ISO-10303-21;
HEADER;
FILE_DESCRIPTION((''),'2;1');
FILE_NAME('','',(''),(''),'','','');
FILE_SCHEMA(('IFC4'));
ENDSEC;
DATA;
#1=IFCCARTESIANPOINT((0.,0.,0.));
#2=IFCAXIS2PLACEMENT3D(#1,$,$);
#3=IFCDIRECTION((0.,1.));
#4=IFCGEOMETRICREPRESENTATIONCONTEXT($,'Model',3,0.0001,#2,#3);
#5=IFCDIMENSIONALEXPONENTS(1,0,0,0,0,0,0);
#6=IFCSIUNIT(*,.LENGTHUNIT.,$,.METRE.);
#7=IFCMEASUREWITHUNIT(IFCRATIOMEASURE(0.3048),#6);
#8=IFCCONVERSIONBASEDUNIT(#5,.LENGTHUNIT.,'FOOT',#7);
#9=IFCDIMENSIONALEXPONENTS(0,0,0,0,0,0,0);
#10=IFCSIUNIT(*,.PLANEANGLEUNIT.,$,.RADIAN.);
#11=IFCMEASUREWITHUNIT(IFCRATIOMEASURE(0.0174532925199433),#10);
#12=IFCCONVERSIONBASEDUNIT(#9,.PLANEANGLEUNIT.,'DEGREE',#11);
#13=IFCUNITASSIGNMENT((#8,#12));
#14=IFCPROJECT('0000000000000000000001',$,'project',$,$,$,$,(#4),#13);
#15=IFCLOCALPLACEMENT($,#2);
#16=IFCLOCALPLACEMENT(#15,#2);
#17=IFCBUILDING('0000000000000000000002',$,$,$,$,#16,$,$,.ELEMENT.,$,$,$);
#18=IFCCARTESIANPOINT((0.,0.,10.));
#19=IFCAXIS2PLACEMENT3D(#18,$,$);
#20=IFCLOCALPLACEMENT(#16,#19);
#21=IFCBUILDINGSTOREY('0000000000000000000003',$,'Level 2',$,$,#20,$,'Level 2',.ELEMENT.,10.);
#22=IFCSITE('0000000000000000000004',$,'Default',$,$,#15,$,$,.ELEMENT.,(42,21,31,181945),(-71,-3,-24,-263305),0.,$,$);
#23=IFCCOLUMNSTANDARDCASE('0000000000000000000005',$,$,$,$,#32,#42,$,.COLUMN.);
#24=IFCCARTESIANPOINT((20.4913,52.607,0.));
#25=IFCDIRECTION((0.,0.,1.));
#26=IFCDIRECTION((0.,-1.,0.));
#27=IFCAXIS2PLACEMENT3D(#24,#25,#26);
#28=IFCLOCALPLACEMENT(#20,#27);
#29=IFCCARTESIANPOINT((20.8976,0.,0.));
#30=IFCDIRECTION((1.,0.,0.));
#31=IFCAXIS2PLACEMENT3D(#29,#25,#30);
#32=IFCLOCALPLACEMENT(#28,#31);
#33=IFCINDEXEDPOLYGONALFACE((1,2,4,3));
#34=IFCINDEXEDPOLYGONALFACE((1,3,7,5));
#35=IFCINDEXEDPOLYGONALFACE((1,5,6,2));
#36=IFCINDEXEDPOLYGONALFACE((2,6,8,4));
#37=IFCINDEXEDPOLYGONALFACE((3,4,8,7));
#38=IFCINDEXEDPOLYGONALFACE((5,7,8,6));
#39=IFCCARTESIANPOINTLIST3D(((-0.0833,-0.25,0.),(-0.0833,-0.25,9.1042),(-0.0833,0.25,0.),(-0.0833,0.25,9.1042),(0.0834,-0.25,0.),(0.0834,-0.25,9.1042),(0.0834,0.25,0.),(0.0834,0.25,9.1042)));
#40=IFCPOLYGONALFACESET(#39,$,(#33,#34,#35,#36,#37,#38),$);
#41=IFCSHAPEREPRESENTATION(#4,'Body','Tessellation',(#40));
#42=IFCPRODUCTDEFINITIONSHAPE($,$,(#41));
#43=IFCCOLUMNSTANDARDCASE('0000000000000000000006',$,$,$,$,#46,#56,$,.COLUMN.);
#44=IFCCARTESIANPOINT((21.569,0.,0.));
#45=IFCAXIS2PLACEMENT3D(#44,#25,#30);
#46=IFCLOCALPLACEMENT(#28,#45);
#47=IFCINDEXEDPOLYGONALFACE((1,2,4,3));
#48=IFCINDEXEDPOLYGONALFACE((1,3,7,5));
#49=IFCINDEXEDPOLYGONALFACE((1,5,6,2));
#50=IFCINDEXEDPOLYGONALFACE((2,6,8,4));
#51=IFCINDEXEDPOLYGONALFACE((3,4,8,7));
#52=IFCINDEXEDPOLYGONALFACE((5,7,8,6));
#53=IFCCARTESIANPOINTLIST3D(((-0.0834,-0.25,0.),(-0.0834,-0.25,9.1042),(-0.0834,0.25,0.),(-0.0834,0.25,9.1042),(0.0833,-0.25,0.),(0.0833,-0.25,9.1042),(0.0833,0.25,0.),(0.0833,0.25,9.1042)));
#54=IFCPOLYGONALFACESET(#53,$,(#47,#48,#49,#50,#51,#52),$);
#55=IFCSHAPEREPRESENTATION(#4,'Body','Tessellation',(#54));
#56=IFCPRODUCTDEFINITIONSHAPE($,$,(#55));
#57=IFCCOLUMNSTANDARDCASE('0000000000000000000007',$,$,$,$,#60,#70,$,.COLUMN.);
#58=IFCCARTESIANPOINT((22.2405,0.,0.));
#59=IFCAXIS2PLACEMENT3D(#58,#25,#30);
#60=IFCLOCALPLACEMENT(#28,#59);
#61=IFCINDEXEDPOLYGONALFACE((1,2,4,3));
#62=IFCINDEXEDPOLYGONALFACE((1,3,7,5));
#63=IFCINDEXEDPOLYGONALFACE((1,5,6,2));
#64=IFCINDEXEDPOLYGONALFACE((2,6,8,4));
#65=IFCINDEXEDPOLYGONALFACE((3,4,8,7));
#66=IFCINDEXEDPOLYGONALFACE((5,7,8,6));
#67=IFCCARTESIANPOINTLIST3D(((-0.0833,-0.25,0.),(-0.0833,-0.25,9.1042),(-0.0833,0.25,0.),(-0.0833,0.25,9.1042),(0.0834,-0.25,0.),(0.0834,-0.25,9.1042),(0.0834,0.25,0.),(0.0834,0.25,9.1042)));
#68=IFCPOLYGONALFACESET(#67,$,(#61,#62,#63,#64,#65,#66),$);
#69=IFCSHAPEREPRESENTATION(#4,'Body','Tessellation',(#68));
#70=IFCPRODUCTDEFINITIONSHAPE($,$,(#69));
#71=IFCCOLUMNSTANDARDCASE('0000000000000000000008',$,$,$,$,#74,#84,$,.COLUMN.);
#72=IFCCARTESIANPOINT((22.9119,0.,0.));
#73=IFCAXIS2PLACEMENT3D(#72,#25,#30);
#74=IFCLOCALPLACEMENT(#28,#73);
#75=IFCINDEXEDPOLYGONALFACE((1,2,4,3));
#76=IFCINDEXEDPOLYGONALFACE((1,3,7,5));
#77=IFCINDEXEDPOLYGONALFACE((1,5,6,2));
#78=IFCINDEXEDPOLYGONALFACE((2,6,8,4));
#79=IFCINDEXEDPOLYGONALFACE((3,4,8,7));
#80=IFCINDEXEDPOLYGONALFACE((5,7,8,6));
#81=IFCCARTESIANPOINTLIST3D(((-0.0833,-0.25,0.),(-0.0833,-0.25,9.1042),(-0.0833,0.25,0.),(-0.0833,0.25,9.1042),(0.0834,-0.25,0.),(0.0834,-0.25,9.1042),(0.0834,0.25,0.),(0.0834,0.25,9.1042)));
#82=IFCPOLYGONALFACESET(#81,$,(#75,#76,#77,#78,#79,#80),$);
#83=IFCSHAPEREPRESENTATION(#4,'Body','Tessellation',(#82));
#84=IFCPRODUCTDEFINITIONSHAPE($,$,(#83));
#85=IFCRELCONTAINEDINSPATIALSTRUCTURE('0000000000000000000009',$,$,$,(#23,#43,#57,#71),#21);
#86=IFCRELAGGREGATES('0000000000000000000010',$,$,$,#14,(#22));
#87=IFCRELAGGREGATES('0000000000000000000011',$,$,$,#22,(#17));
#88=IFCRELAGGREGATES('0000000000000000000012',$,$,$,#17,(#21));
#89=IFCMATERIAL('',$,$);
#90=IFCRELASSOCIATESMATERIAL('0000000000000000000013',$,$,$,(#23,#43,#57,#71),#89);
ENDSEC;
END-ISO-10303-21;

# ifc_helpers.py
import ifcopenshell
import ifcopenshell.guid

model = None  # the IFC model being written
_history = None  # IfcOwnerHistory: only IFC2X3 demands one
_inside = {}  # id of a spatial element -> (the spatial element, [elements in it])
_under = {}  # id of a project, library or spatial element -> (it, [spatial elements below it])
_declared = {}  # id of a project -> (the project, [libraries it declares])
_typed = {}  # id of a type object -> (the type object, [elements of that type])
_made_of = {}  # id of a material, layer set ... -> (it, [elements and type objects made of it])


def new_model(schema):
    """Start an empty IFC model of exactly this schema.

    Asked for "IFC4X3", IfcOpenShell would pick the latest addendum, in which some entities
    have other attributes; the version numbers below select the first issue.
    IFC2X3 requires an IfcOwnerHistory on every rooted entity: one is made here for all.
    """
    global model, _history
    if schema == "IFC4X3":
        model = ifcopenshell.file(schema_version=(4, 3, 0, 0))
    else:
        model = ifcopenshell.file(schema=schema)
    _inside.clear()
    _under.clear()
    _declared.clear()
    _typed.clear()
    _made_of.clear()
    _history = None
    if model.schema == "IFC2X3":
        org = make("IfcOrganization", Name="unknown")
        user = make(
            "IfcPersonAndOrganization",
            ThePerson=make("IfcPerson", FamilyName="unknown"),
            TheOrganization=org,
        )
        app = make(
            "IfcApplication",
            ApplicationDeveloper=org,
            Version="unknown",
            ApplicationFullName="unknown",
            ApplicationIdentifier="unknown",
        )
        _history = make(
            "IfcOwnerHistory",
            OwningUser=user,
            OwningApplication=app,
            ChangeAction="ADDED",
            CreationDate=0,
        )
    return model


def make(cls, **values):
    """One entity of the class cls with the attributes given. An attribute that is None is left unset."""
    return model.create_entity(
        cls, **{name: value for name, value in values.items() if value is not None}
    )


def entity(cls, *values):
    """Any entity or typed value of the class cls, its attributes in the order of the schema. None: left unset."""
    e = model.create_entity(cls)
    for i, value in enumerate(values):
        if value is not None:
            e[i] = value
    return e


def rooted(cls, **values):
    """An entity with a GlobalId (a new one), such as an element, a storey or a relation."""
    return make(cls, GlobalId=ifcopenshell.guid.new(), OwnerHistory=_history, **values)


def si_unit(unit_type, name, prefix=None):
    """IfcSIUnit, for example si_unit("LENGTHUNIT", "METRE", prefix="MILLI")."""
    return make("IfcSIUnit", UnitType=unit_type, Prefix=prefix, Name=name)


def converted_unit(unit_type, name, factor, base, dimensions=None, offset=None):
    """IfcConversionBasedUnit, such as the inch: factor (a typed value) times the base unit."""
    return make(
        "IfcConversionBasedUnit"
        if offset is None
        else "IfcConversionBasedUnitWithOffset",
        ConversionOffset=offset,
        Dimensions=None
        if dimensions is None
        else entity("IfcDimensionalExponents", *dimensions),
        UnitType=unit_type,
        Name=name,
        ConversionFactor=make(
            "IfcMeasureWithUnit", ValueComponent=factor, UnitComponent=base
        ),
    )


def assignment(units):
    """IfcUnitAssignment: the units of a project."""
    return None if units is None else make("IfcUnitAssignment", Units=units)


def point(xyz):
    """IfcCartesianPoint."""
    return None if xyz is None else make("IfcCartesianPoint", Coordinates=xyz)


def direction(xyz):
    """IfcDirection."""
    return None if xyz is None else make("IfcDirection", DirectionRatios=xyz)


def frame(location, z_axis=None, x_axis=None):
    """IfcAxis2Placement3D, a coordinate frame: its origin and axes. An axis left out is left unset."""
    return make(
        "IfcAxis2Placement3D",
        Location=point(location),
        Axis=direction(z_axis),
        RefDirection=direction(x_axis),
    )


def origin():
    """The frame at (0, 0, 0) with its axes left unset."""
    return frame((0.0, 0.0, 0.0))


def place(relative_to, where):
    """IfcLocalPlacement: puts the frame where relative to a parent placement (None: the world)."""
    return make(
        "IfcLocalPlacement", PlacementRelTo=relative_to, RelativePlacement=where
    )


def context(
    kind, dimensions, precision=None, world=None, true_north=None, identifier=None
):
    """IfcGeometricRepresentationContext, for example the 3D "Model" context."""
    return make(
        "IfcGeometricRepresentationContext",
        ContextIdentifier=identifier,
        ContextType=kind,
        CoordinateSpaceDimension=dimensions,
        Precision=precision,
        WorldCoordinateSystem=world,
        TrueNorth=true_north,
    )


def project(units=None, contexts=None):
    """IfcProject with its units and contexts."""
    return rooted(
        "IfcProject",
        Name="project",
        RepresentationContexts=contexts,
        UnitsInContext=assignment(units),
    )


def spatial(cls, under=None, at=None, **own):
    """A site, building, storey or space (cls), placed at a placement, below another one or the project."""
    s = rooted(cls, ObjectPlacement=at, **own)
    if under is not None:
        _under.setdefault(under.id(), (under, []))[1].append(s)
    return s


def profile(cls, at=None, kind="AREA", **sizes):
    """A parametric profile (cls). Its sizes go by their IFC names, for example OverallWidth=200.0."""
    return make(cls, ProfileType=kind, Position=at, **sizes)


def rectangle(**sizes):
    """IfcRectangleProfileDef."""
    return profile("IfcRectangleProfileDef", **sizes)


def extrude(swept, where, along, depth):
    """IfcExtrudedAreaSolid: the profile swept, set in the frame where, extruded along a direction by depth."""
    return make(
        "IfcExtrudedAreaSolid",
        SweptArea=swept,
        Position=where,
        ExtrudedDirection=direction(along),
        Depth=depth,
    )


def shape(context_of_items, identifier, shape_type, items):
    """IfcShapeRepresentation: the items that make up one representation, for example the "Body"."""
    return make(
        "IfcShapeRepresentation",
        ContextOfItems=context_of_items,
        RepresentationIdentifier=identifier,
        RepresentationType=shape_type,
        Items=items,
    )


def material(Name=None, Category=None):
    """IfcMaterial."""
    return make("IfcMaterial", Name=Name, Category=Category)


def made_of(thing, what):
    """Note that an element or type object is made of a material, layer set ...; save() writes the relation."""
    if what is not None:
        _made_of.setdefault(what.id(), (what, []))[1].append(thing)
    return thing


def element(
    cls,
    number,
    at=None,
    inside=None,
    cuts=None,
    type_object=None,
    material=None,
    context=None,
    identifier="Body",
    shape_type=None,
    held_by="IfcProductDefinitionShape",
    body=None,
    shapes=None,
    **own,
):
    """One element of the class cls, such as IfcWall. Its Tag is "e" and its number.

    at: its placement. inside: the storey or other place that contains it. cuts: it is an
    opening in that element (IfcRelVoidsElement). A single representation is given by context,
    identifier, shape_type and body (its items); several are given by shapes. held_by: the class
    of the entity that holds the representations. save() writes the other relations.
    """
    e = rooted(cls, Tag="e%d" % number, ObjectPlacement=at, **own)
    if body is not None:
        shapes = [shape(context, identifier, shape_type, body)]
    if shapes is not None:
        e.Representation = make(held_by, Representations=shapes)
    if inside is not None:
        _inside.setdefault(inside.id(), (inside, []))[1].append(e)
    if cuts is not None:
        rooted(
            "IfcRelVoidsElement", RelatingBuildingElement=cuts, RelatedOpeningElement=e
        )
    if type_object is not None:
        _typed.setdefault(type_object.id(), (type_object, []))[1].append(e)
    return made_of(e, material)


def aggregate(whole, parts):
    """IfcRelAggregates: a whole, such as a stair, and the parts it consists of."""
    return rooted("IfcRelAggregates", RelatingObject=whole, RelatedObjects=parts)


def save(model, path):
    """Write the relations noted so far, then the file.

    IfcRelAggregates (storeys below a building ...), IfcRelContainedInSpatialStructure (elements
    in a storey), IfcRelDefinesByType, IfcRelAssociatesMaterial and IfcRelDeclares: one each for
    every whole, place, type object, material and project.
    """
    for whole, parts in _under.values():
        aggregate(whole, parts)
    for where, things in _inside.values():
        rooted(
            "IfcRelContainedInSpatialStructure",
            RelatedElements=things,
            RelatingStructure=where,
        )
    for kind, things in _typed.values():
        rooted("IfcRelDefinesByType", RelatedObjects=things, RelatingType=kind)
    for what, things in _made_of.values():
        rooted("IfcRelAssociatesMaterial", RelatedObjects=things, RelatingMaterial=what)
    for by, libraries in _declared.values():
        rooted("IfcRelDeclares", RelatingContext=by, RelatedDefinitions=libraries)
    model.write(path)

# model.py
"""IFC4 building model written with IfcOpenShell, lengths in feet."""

from ifc_helpers import new_model, entity, si_unit, converted_unit, direction, frame, origin, place, context, project, spatial, rectangle, extrude, material, element, save


model = new_model("IFC4")

# Units and contexts
model_context = context("Model", 3, precision=0.0001, world=origin(), true_north=direction((0.0, 1.0)))
ifc_project = project(units=[converted_unit("LENGTHUNIT", "FOOT", entity("IfcRatioMeasure", 0.3048), si_unit("LENGTHUNIT", "METRE"), dimensions=[1, 0, 0, 0, 0, 0, 0]), converted_unit("PLANEANGLEUNIT", "DEGREE", entity("IfcRatioMeasure", 0.0174532925199433), si_unit("PLANEANGLEUNIT", "RADIAN"), dimensions=[0, 0, 0, 0, 0, 0, 0])], contexts=[model_context])

# Site, building, storey
site_placement = place(None, origin())
site = spatial("IfcSite", under=ifc_project, at=site_placement, Name="Default", CompositionType="ELEMENT", RefLatitude=(42, 21, 31, 181945), RefLongitude=(-71, -3, -24, -263305), RefElevation=0.0)
building_placement = place(site_placement, origin())
building = spatial("IfcBuilding", under=site, at=building_placement, CompositionType="ELEMENT")
storey_placement = place(building_placement, frame((0.0, 0.0, 10.0)))
storey = spatial("IfcBuildingStorey", under=building, at=storey_placement, Name="Level 2", LongName="Level 2", CompositionType="ELEMENT", Elevation=10.0)

# Columns
ifc_material_1 = material(Name="")
placement_1 = place(storey_placement, frame((20.4913, 52.607, 0.0), z_axis=(0.0, 0.0, 1.0), x_axis=(0.0, -1.0, 0.0)))
for number, where, z_axis, x_axis in (
    (1, (20.8976, 0.0, 0.0), (0.0, 0.0, 1.0), (1.0, 0.0, 0.0)),
    (2, (21.569, 0.0, 0.0), (0.0, 0.0, 1.0), (1.0, 0.0, 0.0)),
    (3, (22.2405, 0.0, 0.0), (0.0, 0.0, 1.0), (1.0, 0.0, 0.0)),
    (4, (22.9119, 0.0, 0.0), (0.0, 0.0, 1.0), (1.0, 0.0, 0.0)),
):
    element("IfcColumnStandardCase", number, at=place(placement_1, frame(where, z_axis=z_axis, x_axis=x_axis)), inside=storey, material=ifc_material_1, PredefinedType="COLUMN", context=model_context, shape_type="SweptSolid", body=[
        extrude(rectangle(XDim=0.1667, YDim=0.5), origin(), (0.0, 0.0, 1.0), 9.1042),
    ])

save(model, "model.ifc")
